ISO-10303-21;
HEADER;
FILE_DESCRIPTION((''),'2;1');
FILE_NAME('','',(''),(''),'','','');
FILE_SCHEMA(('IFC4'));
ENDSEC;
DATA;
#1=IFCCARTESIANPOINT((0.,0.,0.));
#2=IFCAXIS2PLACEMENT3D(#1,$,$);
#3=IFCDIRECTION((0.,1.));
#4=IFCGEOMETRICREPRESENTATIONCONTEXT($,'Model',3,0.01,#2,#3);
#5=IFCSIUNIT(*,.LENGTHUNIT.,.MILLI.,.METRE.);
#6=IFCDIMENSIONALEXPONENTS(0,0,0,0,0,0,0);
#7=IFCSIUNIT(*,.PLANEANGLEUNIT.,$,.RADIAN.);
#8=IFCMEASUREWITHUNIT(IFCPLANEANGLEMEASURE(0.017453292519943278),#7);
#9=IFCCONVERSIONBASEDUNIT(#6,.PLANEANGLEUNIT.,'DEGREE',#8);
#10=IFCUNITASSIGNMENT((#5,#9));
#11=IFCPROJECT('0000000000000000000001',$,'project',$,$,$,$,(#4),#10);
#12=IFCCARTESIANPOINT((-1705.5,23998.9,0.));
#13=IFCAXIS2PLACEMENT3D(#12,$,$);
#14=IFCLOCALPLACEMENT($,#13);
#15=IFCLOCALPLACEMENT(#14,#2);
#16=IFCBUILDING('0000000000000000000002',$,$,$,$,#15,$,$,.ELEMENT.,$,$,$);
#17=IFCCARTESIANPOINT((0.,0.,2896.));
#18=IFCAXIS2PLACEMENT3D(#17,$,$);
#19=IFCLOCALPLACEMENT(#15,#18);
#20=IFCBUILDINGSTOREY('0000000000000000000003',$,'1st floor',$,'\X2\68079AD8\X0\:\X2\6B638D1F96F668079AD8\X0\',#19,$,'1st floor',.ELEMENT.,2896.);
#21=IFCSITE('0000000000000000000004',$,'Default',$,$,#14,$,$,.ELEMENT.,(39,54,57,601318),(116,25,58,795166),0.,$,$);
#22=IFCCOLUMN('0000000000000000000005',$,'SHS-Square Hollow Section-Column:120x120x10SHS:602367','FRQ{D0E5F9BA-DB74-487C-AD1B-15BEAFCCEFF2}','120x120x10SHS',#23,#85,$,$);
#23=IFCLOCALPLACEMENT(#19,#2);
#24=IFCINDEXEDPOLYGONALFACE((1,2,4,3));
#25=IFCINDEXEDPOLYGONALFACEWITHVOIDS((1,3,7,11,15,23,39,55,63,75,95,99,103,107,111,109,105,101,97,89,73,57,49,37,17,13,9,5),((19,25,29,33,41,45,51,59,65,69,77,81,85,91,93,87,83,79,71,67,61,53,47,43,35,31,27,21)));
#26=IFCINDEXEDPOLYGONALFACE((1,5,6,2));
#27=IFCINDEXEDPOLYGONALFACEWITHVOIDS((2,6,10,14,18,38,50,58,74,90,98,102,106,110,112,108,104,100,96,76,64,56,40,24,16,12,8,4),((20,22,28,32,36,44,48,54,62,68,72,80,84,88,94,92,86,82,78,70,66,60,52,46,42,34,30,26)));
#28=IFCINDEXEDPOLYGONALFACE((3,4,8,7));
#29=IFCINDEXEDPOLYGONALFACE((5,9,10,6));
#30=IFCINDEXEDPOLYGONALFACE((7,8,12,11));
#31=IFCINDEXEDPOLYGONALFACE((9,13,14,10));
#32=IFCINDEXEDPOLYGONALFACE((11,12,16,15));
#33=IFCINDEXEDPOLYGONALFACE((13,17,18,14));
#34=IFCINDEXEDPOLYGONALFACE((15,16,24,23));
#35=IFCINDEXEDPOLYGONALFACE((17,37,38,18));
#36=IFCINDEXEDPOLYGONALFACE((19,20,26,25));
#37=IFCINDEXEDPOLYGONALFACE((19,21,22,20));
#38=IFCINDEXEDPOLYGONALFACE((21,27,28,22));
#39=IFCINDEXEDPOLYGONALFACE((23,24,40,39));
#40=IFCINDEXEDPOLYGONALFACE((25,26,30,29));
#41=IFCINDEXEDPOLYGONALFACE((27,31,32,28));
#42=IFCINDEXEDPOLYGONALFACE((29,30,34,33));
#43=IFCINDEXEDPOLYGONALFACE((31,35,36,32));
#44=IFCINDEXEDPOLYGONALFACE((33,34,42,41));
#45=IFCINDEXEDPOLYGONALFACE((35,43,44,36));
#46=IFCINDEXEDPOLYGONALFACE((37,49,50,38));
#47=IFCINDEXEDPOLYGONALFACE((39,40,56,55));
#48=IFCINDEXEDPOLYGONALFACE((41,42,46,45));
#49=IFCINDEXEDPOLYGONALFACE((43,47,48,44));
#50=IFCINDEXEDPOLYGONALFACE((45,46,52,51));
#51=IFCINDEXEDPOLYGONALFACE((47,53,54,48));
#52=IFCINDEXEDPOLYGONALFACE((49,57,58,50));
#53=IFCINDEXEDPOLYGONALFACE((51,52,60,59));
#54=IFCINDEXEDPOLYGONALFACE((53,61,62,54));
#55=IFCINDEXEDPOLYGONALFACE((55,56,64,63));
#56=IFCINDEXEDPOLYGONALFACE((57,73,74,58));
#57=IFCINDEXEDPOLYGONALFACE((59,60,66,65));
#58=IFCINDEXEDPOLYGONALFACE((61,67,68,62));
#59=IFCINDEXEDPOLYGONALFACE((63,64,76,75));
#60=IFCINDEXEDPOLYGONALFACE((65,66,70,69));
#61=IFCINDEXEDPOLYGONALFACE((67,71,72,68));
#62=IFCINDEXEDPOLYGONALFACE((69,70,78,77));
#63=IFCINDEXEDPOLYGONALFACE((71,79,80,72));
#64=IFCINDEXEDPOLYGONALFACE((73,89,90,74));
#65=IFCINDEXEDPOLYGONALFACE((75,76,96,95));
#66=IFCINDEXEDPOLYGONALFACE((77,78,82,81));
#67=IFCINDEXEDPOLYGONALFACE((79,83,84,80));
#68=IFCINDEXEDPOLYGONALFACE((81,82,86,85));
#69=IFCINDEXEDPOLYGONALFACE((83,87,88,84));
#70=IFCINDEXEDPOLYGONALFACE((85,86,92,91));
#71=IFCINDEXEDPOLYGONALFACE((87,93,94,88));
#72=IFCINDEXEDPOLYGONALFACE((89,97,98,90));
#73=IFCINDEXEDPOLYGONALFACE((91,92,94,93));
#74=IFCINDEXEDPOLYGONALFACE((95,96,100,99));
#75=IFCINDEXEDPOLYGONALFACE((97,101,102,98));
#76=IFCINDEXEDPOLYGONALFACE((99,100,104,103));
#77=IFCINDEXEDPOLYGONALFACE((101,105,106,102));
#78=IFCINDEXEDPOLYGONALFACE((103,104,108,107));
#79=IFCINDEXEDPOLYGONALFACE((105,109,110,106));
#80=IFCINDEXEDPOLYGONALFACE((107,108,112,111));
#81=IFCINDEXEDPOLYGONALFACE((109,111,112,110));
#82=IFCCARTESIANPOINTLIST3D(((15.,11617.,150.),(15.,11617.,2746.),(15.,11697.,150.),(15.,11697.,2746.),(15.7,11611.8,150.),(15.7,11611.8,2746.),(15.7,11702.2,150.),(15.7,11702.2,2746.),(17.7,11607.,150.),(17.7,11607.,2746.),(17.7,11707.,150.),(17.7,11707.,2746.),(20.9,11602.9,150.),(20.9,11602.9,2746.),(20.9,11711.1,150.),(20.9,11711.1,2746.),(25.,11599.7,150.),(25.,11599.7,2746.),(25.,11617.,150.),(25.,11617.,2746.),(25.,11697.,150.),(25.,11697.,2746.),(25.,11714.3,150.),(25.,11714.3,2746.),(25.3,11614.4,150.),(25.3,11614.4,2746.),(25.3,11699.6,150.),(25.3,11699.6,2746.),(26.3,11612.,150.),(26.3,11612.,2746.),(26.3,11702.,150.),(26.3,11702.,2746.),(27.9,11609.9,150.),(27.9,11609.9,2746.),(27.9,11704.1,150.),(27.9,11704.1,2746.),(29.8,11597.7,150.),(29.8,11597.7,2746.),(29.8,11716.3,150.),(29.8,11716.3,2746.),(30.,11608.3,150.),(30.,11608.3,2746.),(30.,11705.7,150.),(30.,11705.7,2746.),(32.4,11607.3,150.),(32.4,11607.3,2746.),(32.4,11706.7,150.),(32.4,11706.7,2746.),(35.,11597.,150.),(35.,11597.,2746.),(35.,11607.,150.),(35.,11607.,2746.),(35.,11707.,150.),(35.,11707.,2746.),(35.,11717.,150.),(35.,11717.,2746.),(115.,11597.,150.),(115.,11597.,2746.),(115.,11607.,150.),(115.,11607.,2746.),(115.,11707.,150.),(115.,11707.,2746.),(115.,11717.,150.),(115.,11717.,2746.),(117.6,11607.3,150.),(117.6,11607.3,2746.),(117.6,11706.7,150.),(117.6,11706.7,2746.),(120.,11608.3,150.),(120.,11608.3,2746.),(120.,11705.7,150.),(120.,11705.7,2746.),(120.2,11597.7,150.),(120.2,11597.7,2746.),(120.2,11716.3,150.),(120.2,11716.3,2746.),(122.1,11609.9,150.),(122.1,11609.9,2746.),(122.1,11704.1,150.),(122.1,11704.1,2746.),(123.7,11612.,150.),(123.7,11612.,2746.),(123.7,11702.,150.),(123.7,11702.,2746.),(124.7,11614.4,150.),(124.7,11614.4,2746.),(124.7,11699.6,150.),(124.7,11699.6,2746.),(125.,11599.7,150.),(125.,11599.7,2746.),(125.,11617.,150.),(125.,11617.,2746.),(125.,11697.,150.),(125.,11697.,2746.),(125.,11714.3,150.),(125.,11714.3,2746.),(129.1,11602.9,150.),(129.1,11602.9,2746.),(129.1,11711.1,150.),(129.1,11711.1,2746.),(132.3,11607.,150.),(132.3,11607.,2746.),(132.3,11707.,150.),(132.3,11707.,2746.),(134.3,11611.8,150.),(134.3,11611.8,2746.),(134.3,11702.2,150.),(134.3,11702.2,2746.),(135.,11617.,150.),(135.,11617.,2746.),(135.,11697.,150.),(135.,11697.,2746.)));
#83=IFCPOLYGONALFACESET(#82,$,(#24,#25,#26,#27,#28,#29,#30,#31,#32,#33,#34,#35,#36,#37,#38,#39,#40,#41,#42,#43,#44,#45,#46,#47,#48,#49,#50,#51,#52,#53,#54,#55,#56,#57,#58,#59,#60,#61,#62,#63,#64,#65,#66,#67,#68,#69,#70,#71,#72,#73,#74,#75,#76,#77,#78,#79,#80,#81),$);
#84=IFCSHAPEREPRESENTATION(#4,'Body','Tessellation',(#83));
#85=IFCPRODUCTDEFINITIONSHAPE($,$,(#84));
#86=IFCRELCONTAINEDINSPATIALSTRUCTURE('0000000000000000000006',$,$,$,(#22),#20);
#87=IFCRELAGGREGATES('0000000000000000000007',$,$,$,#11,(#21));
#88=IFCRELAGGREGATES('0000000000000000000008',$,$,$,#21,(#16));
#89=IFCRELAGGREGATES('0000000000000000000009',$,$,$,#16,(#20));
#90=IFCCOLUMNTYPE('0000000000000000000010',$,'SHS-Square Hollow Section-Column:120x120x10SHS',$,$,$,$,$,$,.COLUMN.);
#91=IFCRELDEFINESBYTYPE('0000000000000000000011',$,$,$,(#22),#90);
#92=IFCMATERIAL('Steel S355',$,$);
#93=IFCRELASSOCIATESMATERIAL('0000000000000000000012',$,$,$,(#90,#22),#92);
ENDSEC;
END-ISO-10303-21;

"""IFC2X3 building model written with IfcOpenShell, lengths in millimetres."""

from ifc_helpers import new_model, entity, si_unit, converted_unit, direction, frame, origin, origin_2d, place, context, project, spatial, hollow_rectangle, extrude, clip, halfspace, material, type_object, element, save


model = new_model("IFC2X3")

# Units and contexts
model_context = context("Model", 3, precision=0.01, world=origin(), true_north=direction((0.0, 1.0)))
ifc_project = project(units=[si_unit("LENGTHUNIT", "METRE", prefix="MILLI"), converted_unit("PLANEANGLEUNIT", "DEGREE", entity("IfcPlaneAngleMeasure", 0.017453292519943278), si_unit("PLANEANGLEUNIT", "RADIAN"), dimensions=[0, 0, 0, 0, 0, 0, 0])], contexts=[model_context])

# Site, building, storey
site_placement = place(None, frame((-1705.5, 23998.9, 0.0)))
site = spatial("IfcSite", under=ifc_project, at=site_placement, Name="Default", CompositionType="ELEMENT", RefLatitude=(39, 54, 57, 601318), RefLongitude=(116, 25, 58, 795166), RefElevation=0.0)
building_placement = place(site_placement, origin())
building = spatial("IfcBuilding", under=site, at=building_placement, CompositionType="ELEMENT")
storey_placement = place(building_placement, frame((0.0, 0.0, 2896.0)))
storey = spatial("IfcBuildingStorey", under=building, at=storey_placement, Name="1st floor", ObjectType="标高:正负零标高", LongName="1st floor", CompositionType="ELEMENT", Elevation=2896.0)

# Shared definitions
ifc_material_1 = material(Name="Steel S355")

# Column
column_type_1 = type_object("IfcColumnType", Name="SHS-Square Hollow Section-Column:120x120x10SHS", PredefinedType="COLUMN", material=ifc_material_1)
column_1_placement = place(storey_placement, frame((75.0, 11657.0, 2830.9), z_axis=(0.0, 0.0, 1.0), x_axis=(0.0, -1.0, 0.0)))
element("IfcColumn", 1, at=column_1_placement, inside=storey, type_object=column_type_1, material=ifc_material_1, Name="SHS-Square Hollow Section-Column:120x120x10SHS:602367", Description="FRQ{D0E5F9BA-DB74-487C-AD1B-15BEAFCCEFF2}", ObjectType="120x120x10SHS", context=model_context, shape_type="Clipping", body=[
    clip(clip(extrude(hollow_rectangle(XDim=120.0, YDim=120.0, WallThickness=10.0, InnerFilletRadius=10.0, OuterFilletRadius=20.0, at=origin_2d()), origin(), (0.0, 0.0, -1.0), 2765.7), halfspace(frame((11657.0, -75.0, -84.9), z_axis=(0.0, 0.0, -1.0), x_axis=(0.0, -1.0, 0.0)), True)), halfspace(frame((11657.0, -75.0, -2680.9), z_axis=(0.0, 0.0, 1.0), x_axis=(0.0, 1.0, 0.0)), True)),
])

save(model, "model.ifc")
